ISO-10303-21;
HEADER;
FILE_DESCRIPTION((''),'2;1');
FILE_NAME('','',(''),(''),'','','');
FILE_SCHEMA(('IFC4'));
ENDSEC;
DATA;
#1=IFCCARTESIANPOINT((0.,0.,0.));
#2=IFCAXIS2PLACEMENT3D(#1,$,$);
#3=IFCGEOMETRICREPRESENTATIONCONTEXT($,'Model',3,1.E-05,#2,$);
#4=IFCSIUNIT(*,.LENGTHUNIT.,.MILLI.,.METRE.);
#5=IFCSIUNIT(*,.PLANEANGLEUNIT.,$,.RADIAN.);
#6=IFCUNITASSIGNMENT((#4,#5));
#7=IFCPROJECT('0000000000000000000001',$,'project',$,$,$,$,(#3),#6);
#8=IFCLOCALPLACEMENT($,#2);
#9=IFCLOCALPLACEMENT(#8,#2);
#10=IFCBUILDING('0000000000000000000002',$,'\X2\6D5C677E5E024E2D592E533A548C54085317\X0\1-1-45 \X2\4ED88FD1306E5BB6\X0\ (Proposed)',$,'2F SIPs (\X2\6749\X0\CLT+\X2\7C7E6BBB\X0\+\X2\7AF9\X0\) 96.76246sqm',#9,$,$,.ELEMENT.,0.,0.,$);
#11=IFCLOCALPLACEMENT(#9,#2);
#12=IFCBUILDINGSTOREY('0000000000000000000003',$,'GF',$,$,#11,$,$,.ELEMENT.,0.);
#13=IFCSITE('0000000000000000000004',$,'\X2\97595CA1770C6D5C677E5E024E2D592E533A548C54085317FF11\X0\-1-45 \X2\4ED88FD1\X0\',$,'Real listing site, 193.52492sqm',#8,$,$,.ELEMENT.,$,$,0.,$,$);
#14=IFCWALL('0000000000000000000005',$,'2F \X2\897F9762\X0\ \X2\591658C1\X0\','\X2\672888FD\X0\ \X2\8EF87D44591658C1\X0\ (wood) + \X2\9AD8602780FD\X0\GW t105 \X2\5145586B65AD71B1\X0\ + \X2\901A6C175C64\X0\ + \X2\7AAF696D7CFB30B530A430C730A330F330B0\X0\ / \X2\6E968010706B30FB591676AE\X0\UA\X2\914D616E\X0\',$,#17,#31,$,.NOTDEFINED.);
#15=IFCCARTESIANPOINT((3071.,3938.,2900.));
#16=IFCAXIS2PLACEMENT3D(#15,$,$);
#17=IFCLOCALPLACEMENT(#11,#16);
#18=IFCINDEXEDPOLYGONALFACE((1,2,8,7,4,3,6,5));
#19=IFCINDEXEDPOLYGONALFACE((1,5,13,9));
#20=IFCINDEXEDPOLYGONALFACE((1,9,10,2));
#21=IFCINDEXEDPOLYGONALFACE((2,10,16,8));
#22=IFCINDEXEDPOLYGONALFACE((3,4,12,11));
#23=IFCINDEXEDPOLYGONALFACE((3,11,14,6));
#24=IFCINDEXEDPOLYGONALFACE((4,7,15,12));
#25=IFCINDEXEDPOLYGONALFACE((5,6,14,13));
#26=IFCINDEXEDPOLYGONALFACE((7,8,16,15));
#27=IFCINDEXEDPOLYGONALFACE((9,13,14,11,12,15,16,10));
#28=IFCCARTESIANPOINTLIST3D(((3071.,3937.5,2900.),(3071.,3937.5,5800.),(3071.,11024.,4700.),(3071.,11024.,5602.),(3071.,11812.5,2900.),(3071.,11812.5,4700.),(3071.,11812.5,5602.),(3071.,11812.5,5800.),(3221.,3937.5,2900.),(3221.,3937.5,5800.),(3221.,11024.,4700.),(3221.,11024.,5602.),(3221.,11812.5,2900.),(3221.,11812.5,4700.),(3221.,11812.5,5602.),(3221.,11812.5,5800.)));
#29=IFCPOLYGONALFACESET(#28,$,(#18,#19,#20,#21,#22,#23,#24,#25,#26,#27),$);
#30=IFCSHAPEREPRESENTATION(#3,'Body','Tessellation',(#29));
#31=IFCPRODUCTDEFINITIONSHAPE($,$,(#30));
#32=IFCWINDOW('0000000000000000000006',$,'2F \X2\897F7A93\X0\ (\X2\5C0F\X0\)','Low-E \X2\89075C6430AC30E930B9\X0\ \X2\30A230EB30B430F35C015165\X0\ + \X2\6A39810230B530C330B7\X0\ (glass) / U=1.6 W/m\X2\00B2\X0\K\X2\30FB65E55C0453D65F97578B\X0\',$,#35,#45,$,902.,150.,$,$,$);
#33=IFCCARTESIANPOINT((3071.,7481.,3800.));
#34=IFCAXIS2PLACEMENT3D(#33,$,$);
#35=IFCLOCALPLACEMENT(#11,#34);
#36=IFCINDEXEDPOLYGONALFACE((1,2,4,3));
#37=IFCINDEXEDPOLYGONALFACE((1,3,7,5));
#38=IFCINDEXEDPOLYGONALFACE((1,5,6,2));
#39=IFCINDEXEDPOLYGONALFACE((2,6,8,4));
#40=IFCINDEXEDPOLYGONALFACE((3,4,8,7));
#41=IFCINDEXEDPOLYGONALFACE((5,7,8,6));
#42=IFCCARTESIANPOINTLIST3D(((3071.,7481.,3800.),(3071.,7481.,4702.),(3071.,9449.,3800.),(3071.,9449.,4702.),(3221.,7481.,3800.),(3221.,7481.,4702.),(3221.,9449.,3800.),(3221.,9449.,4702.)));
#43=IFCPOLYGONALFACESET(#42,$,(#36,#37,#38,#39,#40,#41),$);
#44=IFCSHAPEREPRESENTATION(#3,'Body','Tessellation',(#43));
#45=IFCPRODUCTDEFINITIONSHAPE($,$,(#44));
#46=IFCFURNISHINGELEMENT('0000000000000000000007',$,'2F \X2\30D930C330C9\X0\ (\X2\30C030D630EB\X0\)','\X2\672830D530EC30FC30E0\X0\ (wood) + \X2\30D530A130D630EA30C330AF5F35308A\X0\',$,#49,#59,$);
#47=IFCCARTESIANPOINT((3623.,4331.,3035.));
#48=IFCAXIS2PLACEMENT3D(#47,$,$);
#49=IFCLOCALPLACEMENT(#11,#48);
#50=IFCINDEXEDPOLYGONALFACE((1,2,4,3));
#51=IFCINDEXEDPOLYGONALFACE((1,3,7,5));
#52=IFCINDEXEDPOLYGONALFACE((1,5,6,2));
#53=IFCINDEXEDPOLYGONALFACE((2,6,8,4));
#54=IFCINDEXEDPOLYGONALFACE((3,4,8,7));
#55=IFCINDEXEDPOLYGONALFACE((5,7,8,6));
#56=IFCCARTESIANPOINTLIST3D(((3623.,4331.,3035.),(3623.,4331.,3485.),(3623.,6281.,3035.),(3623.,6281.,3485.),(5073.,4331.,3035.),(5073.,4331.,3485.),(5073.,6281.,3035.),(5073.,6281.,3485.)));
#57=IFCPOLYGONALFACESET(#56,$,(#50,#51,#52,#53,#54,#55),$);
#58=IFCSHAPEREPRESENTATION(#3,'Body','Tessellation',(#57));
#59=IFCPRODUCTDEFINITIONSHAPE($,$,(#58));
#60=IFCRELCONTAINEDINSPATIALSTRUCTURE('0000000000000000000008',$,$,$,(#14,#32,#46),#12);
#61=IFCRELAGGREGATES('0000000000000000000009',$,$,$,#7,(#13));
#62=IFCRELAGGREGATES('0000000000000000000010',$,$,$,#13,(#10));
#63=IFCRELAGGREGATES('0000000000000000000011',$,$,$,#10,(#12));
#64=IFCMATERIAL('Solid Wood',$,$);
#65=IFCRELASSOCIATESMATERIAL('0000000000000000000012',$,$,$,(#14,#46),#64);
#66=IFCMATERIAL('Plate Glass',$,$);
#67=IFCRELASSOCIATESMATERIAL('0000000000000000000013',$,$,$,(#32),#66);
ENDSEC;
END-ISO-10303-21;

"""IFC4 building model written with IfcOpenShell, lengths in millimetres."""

from ifc_helpers import new_model, si_unit, frame, frame_2d, origin, place, context, project, spatial, rectangle, extrude, material, element, fill, save


model = new_model("IFC4")

# Units and contexts
model_context = context("Model", 3, precision=1e-05, world=origin())
ifc_project = project(units=[si_unit("LENGTHUNIT", "METRE", prefix="MILLI"), si_unit("PLANEANGLEUNIT", "RADIAN")], contexts=[model_context])

# Site, building, storey
site_placement = place(None, origin())
site = spatial("IfcSite", under=ifc_project, at=site_placement, Name="静岡県浜松市中央区和合北１-1-45 付近", ObjectType="Real listing site, 193.52492sqm", CompositionType="ELEMENT", RefElevation=0.0)
building_placement = place(site_placement, origin())
building = spatial("IfcBuilding", under=site, at=building_placement, Name="浜松市中央区和合北1-1-45 付近の家 (Proposed)", ObjectType="2F SIPs (杉CLT+籾殻+竹) 96.76246sqm", CompositionType="ELEMENT", ElevationOfRefHeight=0.0, ElevationOfTerrain=0.0)
storey_placement = place(building_placement, origin())
storey = spatial("IfcBuildingStorey", under=building, at=storey_placement, Name="GF", CompositionType="ELEMENT", Elevation=0.0)

# Shared definitions
ifc_material_1 = material(Name="Solid Wood")

# Shared definitions
ifc_material_2 = material(Name="Plate Glass")

# Wall, opening, window
wall_1_placement = place(storey_placement, frame((3071.0, 3938.0, 2900.0)))
wall_1 = element("IfcWall", 1, at=wall_1_placement, inside=storey, material=ifc_material_1, Name="2F 西面 外壁", Description="木製 軸組外壁 (wood) + 高性能GW t105 充填断熱 + 通気層 + 窯業系サイディング / 準耐火・外皮UA配慮", PredefinedType="NOTDEFINED", context=model_context, shape_type="SweptSolid", body=[
    extrude(rectangle(XDim=150.0, YDim=7875.0, at=frame_2d((75.0, 3937.0))), frame((3071.0, 3938.0, 2900.0)), (0.0, 0.0, 1.0), 2900.0),
])
opening_1_placement = place(storey_placement, frame((3071.0, 7481.0, 3800.0)))
opening_1 = element("IfcOpeningElement", 2, at=opening_1_placement, cuts=wall_1, PredefinedType="NOTDEFINED", context=model_context, shape_type="SweptSolid", body=[
    extrude(rectangle(XDim=150.0, YDim=1968.0, at=frame_2d((75.0, 984.0))), frame((3071.0, 7481.0, 3800.0)), (0.0, 0.0, 1.0), 902.0),
])
window_1_placement = place(storey_placement, frame((3071.0, 7481.0, 3800.0)))
window_1 = element("IfcWindow", 3, at=window_1_placement, inside=storey, material=ifc_material_2, Name="2F 西窓 (小)", Description="Low-E 複層ガラス アルゴン封入 + 樹脂サッシ (glass) / U=1.6 W/m²K・日射取得型", OverallHeight=902.0, OverallWidth=150.0, context=model_context, shape_type="SweptSolid", body=[
    extrude(rectangle(XDim=150.0, YDim=1968.0, at=frame_2d((75.0, 984.0))), frame((3071.0, 7481.0, 3800.0)), (0.0, 0.0, 1.0), 902.0),
])
fill(opening_1, window_1)

# Furnishing element
furnishing_placement = place(storey_placement, frame((3623.0, 4331.0, 3035.0)))
element("IfcFurnishingElement", 4, at=furnishing_placement, inside=storey, material=ifc_material_1, Name="2F ベッド (ダブル)", Description="木フレーム (wood) + ファブリック張り", context=model_context, shape_type="SweptSolid", body=[
    extrude(rectangle(XDim=1450.0, YDim=1950.0, at=frame_2d((725.0, 975.0))), frame((3623.0, 4331.0, 3035.0)), (0.0, 0.0, 1.0), 450.0),
])

save(model, "model.ifc")
